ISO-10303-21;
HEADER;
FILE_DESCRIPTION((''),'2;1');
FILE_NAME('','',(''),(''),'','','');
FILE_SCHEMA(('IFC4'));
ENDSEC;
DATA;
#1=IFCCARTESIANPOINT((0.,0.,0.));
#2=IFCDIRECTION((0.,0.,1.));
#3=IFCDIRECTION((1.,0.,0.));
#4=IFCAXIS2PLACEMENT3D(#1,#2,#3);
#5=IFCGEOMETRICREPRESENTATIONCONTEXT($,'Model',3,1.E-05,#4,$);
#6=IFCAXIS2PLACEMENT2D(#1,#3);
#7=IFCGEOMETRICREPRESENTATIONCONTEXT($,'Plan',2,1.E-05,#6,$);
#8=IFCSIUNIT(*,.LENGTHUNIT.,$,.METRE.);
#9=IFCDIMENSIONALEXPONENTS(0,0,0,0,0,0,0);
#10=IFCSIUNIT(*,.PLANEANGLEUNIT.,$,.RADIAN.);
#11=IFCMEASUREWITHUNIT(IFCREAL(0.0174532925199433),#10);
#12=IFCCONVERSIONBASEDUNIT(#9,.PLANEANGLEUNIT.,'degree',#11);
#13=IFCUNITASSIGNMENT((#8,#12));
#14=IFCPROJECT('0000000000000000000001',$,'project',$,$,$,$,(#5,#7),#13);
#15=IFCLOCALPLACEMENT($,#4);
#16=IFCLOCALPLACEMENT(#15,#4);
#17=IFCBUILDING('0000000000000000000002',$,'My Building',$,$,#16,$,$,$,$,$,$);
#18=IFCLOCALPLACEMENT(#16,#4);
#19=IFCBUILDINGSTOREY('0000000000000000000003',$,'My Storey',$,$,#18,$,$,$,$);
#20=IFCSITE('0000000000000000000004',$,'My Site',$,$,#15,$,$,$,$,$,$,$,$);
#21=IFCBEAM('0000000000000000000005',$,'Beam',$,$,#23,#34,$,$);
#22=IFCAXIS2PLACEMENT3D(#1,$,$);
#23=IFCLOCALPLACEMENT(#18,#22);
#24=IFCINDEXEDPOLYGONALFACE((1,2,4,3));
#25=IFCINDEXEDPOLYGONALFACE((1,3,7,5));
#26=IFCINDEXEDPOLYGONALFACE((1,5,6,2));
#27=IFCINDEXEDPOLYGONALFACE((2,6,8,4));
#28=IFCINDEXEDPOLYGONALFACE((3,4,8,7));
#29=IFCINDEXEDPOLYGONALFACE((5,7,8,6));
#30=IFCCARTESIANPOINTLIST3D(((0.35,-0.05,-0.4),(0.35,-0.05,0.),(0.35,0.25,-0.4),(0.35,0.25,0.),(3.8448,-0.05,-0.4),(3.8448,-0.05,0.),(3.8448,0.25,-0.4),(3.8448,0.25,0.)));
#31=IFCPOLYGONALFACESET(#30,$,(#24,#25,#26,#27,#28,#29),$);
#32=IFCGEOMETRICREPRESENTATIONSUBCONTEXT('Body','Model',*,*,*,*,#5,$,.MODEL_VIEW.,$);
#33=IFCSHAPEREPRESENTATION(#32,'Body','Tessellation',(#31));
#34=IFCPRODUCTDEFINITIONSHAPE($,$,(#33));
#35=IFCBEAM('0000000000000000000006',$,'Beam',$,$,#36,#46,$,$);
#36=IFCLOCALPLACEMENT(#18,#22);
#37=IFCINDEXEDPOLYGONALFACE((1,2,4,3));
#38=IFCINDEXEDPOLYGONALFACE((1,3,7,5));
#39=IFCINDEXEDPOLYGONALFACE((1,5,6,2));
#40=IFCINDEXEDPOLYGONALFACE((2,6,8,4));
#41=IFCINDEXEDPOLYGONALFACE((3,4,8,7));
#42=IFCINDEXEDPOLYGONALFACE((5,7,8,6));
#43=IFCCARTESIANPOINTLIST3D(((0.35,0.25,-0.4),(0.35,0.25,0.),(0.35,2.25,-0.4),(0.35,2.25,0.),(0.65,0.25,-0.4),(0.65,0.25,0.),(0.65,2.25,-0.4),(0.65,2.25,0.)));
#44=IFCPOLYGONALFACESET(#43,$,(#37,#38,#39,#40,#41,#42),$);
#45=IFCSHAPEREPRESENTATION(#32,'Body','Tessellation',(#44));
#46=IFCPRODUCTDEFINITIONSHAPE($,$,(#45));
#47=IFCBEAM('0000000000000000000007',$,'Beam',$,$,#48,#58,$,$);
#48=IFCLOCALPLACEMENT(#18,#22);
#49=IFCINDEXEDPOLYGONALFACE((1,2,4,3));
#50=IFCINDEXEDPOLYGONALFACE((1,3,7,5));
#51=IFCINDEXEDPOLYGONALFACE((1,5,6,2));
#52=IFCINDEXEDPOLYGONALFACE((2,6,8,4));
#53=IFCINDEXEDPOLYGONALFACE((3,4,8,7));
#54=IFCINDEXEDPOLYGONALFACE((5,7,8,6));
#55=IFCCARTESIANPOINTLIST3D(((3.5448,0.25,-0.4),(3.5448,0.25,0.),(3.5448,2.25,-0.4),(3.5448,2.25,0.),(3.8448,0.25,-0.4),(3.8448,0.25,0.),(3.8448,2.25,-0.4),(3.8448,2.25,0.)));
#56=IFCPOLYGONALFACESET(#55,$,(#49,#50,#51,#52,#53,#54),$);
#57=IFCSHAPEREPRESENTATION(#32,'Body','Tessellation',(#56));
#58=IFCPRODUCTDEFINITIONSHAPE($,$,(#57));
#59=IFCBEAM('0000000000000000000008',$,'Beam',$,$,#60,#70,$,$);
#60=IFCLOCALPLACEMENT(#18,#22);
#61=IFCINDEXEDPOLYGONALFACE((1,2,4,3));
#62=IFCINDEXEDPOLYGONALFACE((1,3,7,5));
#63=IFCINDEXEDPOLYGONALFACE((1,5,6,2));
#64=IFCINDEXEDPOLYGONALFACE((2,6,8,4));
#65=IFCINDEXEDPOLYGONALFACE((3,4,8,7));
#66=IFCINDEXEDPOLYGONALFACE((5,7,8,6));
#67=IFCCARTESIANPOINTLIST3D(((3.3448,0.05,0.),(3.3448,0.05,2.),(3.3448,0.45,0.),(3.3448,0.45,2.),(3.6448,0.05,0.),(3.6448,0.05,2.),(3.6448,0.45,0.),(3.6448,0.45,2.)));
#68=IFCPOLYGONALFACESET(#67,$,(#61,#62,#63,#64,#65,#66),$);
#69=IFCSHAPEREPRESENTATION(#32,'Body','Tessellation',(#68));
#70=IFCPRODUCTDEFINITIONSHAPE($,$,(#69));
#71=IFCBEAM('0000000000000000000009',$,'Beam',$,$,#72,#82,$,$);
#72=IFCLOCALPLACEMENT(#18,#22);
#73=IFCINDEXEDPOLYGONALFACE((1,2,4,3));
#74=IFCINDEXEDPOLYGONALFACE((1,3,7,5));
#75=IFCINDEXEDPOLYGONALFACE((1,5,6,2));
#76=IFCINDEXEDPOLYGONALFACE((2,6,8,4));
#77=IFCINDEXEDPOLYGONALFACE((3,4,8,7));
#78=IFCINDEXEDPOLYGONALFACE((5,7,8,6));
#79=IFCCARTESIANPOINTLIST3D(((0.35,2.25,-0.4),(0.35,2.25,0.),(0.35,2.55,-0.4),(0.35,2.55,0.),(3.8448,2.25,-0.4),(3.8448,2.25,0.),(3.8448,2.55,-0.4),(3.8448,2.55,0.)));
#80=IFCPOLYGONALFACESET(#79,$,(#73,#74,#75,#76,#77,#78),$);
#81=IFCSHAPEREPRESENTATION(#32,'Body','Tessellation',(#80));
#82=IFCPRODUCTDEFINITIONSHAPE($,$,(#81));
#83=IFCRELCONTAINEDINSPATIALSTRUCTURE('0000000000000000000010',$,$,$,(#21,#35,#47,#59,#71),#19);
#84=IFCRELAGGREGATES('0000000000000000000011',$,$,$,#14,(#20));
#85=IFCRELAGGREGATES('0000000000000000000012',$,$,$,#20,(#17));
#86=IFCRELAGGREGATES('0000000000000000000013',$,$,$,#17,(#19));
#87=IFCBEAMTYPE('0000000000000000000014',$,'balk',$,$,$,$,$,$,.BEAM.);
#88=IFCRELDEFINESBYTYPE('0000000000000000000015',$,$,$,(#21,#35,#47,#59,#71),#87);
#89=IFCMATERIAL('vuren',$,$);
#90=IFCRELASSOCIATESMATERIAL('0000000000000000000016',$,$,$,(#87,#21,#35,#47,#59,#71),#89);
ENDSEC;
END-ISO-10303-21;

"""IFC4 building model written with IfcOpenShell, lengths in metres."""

from ifc_helpers import new_model, entity, si_unit, converted_unit, frame, frame_2d, origin_with_axes, place, context, subcontext, project, spatial, rectangle, extrude, material, material_profile, profile_set, profile_usage, type_object, element, save


model = new_model("IFC4")

# Units and contexts
model_context = context("Model", 3, precision=1e-05, world=origin_with_axes())
plan_context = context("Plan", 2, precision=1e-05, world=frame_2d((0.0, 0.0, 0.0), x_axis=(1.0, 0.0, 0.0)))
body_context = subcontext(model_context, "Body", "Model", "MODEL_VIEW")
ifc_project = project(units=[si_unit("LENGTHUNIT", "METRE"), converted_unit("PLANEANGLEUNIT", "degree", entity("IfcReal", 0.0174532925199433), si_unit("PLANEANGLEUNIT", "RADIAN"), dimensions=[0, 0, 0, 0, 0, 0, 0])], contexts=[model_context, plan_context])

# Site, building, storey
site_placement = place(None, origin_with_axes())
site = spatial("IfcSite", under=ifc_project, at=site_placement, Name="My Site")
building_placement = place(site_placement, origin_with_axes())
building = spatial("IfcBuilding", under=site, at=building_placement, Name="My Building")
storey_placement = place(building_placement, origin_with_axes())
storey = spatial("IfcBuildingStorey", under=building, at=storey_placement, Name="My Storey")

# Beams
ifc_material = material(Name="vuren")
ifc_material_profile = material_profile(ifc_material, rectangle(XDim=0.3, YDim=0.4))
ifc_profile_set = profile_set([ifc_material_profile])
ifc_profile_usage_1 = profile_usage(ifc_profile_set)
beam_type = type_object("IfcBeamType", Name="balk", PredefinedType="BEAM", material=ifc_profile_set)
beam_1_placement = place(storey_placement, frame((0.35, 0.1, -0.2), z_axis=(1.0, 0.0, 0.0), x_axis=(0.0, 1.0, 0.0)))
element("IfcBeam", 1, at=beam_1_placement, inside=storey, type_object=beam_type, material=ifc_profile_usage_1, Name="Beam", context=body_context, shape_type="SweptSolid", body=[
    extrude(rectangle(XDim=0.3, YDim=0.4), None, (0.0, 0.0, 1.0), 3.4948),
])
ifc_profile_usage_2 = profile_usage(ifc_profile_set)
beam_2_placement = place(storey_placement, frame((0.5, 0.25, -0.2), z_axis=(0.0, 1.0, 0.0), x_axis=(-1.0, 0.0, 0.0)))
element("IfcBeam", 2, at=beam_2_placement, inside=storey, type_object=beam_type, material=ifc_profile_usage_2, Name="Beam", context=body_context, shape_type="SweptSolid", body=[
    extrude(rectangle(XDim=0.3, YDim=0.4), None, (0.0, 0.0, 1.0), 2.0),
])
ifc_profile_usage_3 = profile_usage(ifc_profile_set)
beam_3_placement = place(storey_placement, frame((3.6948, 0.25, -0.2), z_axis=(0.0, 1.0, 0.0), x_axis=(-1.0, 0.0, 0.0)))
element("IfcBeam", 3, at=beam_3_placement, inside=storey, type_object=beam_type, material=ifc_profile_usage_3, Name="Beam", context=body_context, shape_type="SweptSolid", body=[
    extrude(rectangle(XDim=0.3, YDim=0.4), None, (0.0, 0.0, 1.0), 2.0),
])
ifc_profile_usage_4 = profile_usage(ifc_profile_set)
beam_4_placement = place(storey_placement, frame((3.4948, 0.25, 0.0), z_axis=(0.0, 0.0, 1.0), x_axis=(1.0, 0.0, 0.0)))
element("IfcBeam", 4, at=beam_4_placement, inside=storey, type_object=beam_type, material=ifc_profile_usage_4, Name="Beam", context=body_context, shape_type="SweptSolid", body=[
    extrude(rectangle(XDim=0.3, YDim=0.4), None, (0.0, 0.0, 1.0), 2.0),
])
ifc_profile_usage_5 = profile_usage(ifc_profile_set)
beam_5_placement = place(storey_placement, frame((0.35, 2.4, -0.2), z_axis=(1.0, 0.0, 0.0), x_axis=(0.0, 1.0, 0.0)))
element("IfcBeam", 5, at=beam_5_placement, inside=storey, type_object=beam_type, material=ifc_profile_usage_5, Name="Beam", context=body_context, shape_type="SweptSolid", body=[
    extrude(rectangle(XDim=0.3, YDim=0.4), None, (0.0, 0.0, 1.0), 3.4948),
])

save(model, "model.ifc")
